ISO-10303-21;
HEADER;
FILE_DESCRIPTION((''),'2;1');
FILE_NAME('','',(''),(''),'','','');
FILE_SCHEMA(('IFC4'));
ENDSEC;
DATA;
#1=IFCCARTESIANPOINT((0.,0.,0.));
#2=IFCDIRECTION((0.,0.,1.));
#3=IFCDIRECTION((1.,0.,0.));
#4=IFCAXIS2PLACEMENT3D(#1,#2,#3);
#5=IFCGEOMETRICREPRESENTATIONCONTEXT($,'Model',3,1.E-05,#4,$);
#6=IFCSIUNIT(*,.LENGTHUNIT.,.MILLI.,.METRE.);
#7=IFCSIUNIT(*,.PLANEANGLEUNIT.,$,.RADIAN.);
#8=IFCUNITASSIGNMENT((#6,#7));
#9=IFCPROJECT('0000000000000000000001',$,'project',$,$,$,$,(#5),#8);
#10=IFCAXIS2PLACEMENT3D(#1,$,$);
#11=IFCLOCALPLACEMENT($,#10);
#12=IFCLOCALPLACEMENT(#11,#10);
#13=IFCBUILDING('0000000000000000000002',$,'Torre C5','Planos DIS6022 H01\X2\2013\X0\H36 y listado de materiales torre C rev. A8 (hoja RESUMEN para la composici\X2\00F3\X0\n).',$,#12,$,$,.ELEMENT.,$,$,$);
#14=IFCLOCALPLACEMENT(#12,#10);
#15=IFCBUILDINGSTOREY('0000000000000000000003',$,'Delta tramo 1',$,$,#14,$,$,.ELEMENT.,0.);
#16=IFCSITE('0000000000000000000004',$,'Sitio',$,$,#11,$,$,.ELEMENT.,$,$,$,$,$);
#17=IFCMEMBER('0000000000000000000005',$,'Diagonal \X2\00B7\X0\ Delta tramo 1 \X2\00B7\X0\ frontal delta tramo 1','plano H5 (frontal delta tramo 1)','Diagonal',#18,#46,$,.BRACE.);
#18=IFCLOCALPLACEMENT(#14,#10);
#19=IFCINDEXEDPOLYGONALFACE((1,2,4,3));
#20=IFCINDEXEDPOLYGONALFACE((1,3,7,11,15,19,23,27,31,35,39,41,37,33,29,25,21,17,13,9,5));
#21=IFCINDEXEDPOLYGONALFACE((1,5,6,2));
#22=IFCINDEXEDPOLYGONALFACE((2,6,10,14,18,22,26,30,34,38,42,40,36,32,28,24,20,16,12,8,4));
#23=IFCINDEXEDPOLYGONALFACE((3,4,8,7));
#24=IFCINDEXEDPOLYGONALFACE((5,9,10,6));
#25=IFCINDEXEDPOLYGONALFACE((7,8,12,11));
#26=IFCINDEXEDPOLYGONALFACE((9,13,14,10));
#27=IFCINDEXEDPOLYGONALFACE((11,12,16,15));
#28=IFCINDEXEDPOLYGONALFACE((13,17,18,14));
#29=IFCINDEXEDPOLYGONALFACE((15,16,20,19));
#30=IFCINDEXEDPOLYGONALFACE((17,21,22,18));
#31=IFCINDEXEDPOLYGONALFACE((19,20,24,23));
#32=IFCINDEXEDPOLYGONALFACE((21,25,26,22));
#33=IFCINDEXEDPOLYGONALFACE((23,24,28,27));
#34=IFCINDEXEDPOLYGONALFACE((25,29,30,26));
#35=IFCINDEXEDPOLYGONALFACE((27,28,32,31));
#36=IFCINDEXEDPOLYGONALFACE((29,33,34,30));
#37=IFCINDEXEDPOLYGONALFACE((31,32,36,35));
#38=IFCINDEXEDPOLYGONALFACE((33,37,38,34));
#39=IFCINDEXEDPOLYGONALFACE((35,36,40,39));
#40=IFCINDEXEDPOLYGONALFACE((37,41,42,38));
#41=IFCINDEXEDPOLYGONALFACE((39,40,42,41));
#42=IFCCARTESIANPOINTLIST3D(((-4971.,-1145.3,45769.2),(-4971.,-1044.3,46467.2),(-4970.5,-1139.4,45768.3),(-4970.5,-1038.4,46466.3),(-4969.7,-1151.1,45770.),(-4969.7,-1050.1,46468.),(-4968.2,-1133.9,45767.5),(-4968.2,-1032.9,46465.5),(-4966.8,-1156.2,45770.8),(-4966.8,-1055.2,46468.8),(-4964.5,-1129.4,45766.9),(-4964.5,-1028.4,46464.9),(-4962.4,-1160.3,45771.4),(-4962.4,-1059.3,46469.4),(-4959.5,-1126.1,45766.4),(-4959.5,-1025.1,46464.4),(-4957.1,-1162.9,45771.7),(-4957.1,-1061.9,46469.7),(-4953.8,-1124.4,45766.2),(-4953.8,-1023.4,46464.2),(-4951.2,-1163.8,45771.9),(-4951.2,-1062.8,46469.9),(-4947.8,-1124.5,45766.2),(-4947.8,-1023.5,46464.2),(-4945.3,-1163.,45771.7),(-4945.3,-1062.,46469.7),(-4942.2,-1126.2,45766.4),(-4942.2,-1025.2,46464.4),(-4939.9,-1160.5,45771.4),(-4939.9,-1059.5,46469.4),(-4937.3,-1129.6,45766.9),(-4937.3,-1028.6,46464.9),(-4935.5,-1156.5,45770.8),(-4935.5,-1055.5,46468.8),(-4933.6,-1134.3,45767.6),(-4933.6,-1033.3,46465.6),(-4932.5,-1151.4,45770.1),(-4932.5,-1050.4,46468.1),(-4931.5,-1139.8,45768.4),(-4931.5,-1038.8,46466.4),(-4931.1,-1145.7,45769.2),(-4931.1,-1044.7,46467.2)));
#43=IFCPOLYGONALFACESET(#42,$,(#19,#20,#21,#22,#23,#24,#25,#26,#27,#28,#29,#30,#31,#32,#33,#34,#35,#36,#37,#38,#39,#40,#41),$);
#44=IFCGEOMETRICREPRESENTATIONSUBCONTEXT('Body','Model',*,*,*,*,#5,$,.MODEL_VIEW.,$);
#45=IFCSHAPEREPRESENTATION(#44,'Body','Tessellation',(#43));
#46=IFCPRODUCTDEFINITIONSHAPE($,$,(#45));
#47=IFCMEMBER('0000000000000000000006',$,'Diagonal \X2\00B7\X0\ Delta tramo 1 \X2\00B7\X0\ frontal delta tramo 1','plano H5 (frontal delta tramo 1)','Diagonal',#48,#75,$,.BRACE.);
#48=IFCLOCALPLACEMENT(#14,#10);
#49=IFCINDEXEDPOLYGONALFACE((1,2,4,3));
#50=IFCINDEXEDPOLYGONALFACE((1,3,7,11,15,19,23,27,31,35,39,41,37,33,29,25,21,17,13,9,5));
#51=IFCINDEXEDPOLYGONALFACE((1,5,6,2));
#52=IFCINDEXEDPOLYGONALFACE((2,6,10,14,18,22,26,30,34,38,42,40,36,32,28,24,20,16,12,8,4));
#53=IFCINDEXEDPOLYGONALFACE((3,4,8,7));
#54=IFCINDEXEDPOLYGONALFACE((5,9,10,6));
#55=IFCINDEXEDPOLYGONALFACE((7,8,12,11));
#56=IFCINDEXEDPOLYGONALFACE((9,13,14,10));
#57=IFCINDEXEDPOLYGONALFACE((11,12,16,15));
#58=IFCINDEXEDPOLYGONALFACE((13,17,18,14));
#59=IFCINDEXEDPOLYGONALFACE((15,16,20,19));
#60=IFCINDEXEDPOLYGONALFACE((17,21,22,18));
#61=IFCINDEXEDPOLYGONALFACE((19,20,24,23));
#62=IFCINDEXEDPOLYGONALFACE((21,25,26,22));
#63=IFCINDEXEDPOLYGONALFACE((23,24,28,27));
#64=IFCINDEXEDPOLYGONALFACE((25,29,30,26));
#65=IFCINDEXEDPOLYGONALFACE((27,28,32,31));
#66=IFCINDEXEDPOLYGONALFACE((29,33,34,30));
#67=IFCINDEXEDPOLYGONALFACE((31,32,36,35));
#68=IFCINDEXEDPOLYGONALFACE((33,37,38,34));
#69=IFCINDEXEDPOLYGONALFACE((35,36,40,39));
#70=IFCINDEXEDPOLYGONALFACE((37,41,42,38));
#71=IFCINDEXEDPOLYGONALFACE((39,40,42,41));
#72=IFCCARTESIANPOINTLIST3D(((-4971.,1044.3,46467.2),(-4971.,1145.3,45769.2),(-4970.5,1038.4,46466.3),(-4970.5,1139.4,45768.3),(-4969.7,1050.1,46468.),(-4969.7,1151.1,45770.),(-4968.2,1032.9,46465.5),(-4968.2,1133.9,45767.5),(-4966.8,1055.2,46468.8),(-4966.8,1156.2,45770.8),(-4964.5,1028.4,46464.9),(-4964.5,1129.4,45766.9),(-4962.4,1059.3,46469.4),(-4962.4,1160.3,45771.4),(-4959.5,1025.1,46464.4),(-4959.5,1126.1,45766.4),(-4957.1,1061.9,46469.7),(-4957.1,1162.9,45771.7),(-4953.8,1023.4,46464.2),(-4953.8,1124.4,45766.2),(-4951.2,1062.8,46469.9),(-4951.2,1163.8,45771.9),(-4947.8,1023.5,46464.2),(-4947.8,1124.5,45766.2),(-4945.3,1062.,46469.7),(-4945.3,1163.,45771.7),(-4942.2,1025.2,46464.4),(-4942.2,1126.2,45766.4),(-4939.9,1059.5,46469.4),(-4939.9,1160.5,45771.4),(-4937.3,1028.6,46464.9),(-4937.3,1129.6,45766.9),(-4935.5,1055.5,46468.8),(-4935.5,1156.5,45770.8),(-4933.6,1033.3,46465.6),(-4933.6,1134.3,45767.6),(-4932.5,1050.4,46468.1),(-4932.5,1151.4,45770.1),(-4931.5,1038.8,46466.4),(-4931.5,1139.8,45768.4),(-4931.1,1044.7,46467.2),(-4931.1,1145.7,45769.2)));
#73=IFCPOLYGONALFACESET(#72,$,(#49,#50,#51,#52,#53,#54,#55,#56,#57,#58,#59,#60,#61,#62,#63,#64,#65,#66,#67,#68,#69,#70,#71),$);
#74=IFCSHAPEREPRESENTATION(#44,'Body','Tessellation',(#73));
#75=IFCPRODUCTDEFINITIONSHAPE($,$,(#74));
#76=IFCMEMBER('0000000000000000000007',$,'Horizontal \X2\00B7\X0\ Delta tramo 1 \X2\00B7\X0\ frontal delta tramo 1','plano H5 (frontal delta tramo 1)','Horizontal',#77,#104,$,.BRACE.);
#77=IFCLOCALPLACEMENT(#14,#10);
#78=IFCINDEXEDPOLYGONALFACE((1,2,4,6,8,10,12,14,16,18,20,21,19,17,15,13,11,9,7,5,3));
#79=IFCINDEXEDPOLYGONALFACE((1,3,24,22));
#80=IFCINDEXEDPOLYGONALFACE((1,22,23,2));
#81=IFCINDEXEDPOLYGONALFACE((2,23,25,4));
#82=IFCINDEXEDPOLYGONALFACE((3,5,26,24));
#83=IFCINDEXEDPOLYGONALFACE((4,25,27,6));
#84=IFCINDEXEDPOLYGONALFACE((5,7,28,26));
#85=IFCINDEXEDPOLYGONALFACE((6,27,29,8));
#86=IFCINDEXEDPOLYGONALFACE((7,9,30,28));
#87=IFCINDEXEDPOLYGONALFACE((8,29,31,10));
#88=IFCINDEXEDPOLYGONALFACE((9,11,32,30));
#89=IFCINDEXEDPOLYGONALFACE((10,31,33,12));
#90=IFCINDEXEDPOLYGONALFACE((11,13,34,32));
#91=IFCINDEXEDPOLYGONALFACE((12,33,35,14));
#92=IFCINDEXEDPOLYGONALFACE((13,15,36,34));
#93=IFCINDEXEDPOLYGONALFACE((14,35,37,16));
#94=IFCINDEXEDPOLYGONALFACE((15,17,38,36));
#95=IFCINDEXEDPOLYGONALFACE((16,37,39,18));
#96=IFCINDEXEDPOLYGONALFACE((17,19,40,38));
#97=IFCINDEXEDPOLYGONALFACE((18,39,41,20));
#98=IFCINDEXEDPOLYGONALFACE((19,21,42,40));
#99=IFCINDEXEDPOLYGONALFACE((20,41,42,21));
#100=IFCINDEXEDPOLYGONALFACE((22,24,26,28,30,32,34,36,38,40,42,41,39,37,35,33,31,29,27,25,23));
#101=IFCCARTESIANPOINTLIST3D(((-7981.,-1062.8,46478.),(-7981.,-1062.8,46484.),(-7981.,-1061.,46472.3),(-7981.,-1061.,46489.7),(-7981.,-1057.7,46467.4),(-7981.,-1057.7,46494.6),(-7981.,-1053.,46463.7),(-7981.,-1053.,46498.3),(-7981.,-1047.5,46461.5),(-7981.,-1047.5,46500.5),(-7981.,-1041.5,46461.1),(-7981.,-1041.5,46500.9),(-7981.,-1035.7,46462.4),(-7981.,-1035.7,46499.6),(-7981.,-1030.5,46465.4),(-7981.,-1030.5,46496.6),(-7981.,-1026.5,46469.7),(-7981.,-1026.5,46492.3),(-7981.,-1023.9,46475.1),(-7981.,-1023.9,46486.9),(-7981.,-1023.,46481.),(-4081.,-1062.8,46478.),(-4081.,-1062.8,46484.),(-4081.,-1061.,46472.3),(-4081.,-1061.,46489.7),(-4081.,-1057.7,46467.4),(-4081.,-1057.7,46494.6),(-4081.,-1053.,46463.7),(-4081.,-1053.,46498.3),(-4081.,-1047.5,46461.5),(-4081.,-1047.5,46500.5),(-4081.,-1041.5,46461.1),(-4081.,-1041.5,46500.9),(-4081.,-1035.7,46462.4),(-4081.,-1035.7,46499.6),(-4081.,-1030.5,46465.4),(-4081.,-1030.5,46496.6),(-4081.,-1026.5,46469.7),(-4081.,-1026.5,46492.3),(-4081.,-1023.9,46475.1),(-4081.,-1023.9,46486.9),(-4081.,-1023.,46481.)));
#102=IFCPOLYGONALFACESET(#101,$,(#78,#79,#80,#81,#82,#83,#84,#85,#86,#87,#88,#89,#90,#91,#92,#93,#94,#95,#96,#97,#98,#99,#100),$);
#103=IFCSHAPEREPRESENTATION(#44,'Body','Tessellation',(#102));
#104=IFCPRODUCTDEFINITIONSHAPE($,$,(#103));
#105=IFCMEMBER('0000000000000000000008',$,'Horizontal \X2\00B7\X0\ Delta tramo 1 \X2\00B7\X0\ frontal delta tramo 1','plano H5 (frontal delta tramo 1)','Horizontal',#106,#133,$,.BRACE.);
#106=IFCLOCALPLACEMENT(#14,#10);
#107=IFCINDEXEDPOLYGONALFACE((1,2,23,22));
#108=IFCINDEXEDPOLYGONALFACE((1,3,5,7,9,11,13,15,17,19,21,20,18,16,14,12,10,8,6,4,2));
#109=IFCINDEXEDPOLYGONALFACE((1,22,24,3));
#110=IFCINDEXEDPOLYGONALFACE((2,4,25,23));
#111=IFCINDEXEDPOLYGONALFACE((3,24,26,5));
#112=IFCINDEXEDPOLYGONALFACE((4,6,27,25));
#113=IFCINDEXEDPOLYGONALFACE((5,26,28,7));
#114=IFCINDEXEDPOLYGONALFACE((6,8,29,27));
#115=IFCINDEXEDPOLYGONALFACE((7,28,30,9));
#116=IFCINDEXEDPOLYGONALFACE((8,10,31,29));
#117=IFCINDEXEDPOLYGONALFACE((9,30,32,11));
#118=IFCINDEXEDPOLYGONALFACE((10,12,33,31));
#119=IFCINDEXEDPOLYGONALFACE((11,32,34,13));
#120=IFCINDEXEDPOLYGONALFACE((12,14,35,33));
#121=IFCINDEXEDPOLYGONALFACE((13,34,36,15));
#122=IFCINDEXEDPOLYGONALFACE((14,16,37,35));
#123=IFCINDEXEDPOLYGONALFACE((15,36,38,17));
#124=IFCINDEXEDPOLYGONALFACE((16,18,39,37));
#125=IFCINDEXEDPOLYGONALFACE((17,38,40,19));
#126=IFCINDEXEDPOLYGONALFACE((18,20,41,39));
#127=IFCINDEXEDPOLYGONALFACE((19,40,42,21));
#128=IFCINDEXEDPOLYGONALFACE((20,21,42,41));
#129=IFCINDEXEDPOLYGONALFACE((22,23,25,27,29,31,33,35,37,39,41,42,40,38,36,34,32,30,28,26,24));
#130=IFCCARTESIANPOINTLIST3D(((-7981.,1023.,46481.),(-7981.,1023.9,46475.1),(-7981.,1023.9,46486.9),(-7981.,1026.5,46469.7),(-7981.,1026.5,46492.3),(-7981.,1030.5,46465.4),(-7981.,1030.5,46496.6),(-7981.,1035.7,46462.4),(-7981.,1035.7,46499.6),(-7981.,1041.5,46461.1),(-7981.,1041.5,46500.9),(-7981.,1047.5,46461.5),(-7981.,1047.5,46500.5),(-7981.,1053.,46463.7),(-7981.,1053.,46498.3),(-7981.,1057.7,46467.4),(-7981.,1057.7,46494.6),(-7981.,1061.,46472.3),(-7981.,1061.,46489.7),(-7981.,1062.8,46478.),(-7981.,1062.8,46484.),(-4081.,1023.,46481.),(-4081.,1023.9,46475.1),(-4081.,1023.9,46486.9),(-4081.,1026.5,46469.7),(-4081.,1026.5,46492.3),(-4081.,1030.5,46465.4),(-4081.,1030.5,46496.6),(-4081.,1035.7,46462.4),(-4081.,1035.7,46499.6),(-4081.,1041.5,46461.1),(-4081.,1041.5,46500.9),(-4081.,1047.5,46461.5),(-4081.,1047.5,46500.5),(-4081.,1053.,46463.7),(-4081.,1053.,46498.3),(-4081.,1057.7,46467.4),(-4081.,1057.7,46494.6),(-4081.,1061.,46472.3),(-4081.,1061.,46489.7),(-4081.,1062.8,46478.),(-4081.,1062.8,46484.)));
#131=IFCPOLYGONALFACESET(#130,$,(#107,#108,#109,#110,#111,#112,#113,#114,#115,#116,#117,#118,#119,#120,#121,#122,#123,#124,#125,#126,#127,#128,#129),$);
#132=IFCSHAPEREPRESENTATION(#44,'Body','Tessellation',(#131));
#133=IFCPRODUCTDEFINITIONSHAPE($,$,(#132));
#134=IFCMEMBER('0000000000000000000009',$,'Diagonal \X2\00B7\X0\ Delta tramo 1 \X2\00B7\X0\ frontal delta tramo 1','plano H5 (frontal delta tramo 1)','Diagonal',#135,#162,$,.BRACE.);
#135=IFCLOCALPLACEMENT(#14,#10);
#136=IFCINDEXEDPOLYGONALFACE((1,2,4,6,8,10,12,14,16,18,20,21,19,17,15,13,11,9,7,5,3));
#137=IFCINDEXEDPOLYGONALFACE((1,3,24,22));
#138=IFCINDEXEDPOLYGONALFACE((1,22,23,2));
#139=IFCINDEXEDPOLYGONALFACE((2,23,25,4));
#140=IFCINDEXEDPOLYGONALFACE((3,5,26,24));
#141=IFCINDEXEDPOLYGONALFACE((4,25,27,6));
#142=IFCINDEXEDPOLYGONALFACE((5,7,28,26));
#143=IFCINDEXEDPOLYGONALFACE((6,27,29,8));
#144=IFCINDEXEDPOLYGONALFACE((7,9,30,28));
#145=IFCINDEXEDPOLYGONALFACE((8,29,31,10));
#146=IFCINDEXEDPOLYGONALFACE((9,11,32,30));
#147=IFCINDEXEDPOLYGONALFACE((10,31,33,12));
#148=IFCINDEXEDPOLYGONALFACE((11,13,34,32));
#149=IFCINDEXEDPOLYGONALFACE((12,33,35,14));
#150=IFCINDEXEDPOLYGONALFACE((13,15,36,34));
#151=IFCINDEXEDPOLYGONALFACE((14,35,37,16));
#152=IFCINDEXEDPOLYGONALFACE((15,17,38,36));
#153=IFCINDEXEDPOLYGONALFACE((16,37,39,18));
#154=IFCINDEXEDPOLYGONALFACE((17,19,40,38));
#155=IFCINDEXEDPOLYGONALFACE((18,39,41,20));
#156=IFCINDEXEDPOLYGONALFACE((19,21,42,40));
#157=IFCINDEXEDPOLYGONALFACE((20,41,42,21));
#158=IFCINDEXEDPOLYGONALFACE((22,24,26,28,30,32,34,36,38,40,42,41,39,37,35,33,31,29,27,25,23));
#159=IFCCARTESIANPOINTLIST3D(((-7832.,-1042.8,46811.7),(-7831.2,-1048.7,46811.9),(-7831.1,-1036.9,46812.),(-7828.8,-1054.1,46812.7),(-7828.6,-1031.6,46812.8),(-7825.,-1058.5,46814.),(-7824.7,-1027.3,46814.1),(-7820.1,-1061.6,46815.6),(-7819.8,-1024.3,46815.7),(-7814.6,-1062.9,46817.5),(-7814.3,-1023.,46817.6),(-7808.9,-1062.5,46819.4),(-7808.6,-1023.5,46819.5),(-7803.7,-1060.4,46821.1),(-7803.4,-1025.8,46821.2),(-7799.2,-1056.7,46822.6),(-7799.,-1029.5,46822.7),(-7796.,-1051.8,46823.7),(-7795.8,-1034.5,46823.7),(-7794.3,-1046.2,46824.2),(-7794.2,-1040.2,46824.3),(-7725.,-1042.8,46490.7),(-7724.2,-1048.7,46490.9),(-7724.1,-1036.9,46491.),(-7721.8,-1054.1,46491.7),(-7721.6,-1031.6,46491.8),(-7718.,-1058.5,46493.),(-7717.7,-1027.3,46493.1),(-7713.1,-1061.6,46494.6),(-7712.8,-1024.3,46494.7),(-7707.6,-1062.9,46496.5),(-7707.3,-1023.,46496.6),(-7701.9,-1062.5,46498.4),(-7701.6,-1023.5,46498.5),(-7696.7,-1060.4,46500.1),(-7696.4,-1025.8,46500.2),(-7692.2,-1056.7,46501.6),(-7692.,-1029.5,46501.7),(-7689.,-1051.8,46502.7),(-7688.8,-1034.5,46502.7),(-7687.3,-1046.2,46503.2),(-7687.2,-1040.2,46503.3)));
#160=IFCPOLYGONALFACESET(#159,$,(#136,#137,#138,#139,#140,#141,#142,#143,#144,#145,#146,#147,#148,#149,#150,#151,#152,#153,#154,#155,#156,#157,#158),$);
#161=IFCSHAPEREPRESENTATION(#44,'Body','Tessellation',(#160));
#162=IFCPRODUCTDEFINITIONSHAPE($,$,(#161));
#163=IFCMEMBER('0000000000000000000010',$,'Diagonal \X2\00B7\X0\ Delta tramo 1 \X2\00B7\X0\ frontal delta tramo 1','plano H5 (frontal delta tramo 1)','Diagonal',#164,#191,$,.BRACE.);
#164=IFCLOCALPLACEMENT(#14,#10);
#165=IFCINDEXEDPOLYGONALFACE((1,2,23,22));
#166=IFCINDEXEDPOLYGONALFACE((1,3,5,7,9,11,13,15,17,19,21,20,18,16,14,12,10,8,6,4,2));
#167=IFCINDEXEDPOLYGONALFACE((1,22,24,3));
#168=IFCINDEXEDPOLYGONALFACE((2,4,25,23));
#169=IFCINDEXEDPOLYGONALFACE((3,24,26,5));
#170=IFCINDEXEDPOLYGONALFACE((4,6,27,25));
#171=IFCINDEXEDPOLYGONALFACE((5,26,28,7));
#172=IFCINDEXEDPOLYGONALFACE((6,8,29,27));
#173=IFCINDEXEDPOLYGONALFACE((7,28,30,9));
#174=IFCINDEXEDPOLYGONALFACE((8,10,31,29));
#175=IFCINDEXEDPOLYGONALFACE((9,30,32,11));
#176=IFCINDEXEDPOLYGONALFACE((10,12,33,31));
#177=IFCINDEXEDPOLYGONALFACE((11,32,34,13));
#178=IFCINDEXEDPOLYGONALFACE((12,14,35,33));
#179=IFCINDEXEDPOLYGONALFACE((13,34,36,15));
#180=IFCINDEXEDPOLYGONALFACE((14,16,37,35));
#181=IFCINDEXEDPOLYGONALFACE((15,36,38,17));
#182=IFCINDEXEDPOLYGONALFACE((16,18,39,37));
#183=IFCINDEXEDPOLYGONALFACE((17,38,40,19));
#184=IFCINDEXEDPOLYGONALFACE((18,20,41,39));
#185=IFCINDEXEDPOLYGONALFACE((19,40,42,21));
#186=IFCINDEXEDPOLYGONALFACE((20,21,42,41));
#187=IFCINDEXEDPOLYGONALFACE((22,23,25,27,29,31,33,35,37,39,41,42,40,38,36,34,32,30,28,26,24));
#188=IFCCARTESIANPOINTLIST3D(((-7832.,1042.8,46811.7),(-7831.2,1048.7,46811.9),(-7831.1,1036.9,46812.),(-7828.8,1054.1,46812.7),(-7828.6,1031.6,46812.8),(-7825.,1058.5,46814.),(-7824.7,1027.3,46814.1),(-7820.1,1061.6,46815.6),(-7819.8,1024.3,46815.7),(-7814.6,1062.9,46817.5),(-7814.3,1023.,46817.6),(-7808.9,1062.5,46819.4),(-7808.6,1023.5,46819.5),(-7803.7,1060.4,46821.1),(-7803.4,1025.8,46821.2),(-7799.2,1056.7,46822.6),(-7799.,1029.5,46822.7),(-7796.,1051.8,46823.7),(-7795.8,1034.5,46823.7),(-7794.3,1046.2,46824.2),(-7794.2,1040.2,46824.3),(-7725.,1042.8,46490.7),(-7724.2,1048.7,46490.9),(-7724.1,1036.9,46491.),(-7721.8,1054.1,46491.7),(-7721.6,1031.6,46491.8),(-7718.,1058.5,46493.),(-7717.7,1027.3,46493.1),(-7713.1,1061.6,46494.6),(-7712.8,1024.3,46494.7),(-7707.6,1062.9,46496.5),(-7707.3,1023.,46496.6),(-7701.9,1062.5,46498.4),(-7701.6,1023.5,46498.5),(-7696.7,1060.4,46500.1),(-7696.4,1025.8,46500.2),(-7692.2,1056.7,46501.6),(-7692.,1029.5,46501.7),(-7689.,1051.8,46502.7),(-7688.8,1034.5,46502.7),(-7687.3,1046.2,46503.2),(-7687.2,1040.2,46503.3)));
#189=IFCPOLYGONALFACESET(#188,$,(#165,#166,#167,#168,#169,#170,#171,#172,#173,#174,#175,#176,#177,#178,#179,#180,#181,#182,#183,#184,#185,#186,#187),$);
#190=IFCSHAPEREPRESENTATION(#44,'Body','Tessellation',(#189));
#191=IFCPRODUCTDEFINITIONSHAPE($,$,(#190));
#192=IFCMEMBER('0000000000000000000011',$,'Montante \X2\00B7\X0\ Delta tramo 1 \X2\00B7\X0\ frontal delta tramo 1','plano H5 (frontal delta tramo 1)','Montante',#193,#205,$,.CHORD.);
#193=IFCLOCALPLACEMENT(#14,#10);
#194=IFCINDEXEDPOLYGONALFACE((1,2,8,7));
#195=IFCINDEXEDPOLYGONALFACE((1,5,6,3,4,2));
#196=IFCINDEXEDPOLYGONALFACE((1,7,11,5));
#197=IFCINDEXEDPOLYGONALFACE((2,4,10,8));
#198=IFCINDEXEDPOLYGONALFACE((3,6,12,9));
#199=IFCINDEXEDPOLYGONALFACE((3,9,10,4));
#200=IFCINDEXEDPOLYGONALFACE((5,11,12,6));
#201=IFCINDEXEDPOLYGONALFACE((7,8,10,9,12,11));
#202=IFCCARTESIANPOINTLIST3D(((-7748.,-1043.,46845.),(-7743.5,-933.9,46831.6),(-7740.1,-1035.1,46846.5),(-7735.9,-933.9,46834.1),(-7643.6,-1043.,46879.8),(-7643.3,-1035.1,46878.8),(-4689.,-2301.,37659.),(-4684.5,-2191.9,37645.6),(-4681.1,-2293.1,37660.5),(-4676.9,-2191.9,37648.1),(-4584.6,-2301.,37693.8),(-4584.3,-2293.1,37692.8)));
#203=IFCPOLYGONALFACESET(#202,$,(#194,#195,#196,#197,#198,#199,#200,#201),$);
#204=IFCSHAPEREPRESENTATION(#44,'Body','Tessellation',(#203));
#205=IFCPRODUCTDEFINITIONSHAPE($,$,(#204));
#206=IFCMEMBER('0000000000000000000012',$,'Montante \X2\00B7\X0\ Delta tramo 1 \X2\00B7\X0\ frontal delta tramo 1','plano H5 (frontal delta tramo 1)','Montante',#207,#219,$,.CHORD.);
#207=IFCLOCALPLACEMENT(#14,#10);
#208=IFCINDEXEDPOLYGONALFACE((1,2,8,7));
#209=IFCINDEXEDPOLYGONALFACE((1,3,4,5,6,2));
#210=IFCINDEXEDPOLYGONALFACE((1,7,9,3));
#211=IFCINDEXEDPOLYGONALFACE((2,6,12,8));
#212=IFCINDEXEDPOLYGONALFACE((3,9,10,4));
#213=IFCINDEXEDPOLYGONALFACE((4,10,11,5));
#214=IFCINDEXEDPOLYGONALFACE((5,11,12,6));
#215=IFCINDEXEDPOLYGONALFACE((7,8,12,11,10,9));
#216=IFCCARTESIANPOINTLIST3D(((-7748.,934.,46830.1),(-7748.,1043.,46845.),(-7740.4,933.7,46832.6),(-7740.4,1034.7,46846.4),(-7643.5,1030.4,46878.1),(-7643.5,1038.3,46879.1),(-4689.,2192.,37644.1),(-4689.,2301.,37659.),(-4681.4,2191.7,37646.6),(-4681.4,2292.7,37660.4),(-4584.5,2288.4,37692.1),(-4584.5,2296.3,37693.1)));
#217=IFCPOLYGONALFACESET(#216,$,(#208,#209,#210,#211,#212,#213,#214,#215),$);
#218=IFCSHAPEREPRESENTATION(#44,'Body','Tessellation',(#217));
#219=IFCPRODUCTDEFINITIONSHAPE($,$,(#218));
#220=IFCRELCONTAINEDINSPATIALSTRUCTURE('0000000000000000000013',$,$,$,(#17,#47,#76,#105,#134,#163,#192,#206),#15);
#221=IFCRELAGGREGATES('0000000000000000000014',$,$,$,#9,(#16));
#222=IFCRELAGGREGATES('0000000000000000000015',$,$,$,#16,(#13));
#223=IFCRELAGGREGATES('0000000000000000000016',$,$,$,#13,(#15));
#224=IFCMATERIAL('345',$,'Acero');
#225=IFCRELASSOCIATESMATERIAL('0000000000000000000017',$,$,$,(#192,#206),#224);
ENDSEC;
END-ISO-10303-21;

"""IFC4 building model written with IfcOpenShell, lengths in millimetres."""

from ifc_helpers import new_model, si_unit, frame, frame_2d, origin, origin_with_axes, place, context, subcontext, project, spatial, circle, l_section, extrude, material, element, save


model = new_model("IFC4")

# Units and contexts
model_context = context("Model", 3, precision=1e-05, world=origin_with_axes())
body_context = subcontext(model_context, "Body", "Model", "MODEL_VIEW")
ifc_project = project(units=[si_unit("LENGTHUNIT", "METRE", prefix="MILLI"), si_unit("PLANEANGLEUNIT", "RADIAN")], contexts=[model_context])

# Site, building, storey
site_placement = place(None, origin())
site = spatial("IfcSite", under=ifc_project, at=site_placement, Name="Sitio", CompositionType="ELEMENT")
building_placement = place(site_placement, origin())
building = spatial("IfcBuilding", under=site, at=building_placement, Name="Torre C5", Description="Planos DIS6022 H01–H36 y listado de materiales torre C rev. A8 (hoja RESUMEN para la composición).", CompositionType="ELEMENT")
storey_placement = place(building_placement, origin())
storey = spatial("IfcBuildingStorey", under=building, at=storey_placement, Name="Delta tramo 1", CompositionType="ELEMENT", Elevation=0.0)

# Members
for number, where, z_axis, x_axis, name in (
    (1, (-4951.0, -1144.0, 45769.0), (0.0, 0.143208, 0.989693), (0.976933, 0.211345, -0.030581), "Diagonal · Delta tramo 1 · frontal delta tramo 1"),
    (2, (-4951.0, 1144.0, 45769.0), (0.0, -0.143208, 0.989693), (0.976933, -0.211345, -0.030581), "Diagonal · Delta tramo 1 · frontal delta tramo 1"),
):
    element("IfcMember", number, at=place(storey_placement, frame(where, z_axis=z_axis, x_axis=x_axis)), inside=storey, Name=name, Description="plano H5 (frontal delta tramo 1)", ObjectType="Diagonal", PredefinedType="BRACE", context=body_context, shape_type="SweptSolid", body=[
        extrude(circle(Radius=20.0), None, (0.0, 0.0, 1.0), 705.3),
    ])
for number, where, z_axis, x_axis, name in (
    (3, (-4081.0, -1043.0, 46481.0), (-1.0, 0.0, 0.0), (0.0, 1.0, 0.0), "Horizontal · Delta tramo 1 · frontal delta tramo 1"),
    (4, (-4081.0, 1043.0, 46481.0), (-1.0, 0.0, 0.0), (0.0, -1.0, 0.0), "Horizontal · Delta tramo 1 · frontal delta tramo 1"),
):
    element("IfcMember", number, at=place(storey_placement, frame(where, z_axis=z_axis, x_axis=x_axis)), inside=storey, Name=name, Description="plano H5 (frontal delta tramo 1)", ObjectType="Horizontal", PredefinedType="BRACE", context=body_context, shape_type="SweptSolid", body=[
        extrude(circle(Radius=20.0), None, (0.0, 0.0, 1.0), 3900.0),
    ])
for number, where, z_axis, x_axis, name in (
    (5, (-7706.0, -1043.0, 46497.0), (-0.316228, 0.0, 0.948683), (0.939302, 0.140286, 0.313101), "Diagonal · Delta tramo 1 · frontal delta tramo 1"),
    (6, (-7706.0, 1043.0, 46497.0), (-0.316228, 0.0, 0.948683), (0.939302, -0.140286, 0.313101), "Diagonal · Delta tramo 1 · frontal delta tramo 1"),
):
    element("IfcMember", number, at=place(storey_placement, frame(where, z_axis=z_axis, x_axis=x_axis)), inside=storey, Name=name, Description="plano H5 (frontal delta tramo 1)", ObjectType="Diagonal", PredefinedType="BRACE", context=body_context, shape_type="SweptSolid", body=[
        extrude(circle(Radius=20.0), None, (0.0, 0.0, 1.0), 338.4),
    ])
ifc_material = material(Name="345", Category="Acero")
for number, where, z_axis, x_axis, name in (
    (7, (-7748.0, -1043.0, 46845.0), (0.313315, -0.128849, -0.940867), (0.04071, 0.991664, -0.122249), "Montante · Delta tramo 1 · frontal delta tramo 1"),
    (8, (-7748.0, 1043.0, 46845.0), (0.313315, 0.128849, -0.940867), (0.949649, -0.042511, 0.310418), "Montante · Delta tramo 1 · frontal delta tramo 1"),
):
    element("IfcMember", number, at=place(storey_placement, frame(where, z_axis=z_axis, x_axis=x_axis)), inside=storey, material=ifc_material, Name=name, Description="plano H5 (frontal delta tramo 1)", ObjectType="Montante", PredefinedType="CHORD", context=body_context, shape_type="SweptSolid", body=[
        extrude(l_section(Depth=110.0, Width=110.0, Thickness=8.0, at=frame_2d((55.0, 55.0))), None, (0.0, 0.0, 1.0), 9763.3),
    ])

save(model, "model.ifc")
